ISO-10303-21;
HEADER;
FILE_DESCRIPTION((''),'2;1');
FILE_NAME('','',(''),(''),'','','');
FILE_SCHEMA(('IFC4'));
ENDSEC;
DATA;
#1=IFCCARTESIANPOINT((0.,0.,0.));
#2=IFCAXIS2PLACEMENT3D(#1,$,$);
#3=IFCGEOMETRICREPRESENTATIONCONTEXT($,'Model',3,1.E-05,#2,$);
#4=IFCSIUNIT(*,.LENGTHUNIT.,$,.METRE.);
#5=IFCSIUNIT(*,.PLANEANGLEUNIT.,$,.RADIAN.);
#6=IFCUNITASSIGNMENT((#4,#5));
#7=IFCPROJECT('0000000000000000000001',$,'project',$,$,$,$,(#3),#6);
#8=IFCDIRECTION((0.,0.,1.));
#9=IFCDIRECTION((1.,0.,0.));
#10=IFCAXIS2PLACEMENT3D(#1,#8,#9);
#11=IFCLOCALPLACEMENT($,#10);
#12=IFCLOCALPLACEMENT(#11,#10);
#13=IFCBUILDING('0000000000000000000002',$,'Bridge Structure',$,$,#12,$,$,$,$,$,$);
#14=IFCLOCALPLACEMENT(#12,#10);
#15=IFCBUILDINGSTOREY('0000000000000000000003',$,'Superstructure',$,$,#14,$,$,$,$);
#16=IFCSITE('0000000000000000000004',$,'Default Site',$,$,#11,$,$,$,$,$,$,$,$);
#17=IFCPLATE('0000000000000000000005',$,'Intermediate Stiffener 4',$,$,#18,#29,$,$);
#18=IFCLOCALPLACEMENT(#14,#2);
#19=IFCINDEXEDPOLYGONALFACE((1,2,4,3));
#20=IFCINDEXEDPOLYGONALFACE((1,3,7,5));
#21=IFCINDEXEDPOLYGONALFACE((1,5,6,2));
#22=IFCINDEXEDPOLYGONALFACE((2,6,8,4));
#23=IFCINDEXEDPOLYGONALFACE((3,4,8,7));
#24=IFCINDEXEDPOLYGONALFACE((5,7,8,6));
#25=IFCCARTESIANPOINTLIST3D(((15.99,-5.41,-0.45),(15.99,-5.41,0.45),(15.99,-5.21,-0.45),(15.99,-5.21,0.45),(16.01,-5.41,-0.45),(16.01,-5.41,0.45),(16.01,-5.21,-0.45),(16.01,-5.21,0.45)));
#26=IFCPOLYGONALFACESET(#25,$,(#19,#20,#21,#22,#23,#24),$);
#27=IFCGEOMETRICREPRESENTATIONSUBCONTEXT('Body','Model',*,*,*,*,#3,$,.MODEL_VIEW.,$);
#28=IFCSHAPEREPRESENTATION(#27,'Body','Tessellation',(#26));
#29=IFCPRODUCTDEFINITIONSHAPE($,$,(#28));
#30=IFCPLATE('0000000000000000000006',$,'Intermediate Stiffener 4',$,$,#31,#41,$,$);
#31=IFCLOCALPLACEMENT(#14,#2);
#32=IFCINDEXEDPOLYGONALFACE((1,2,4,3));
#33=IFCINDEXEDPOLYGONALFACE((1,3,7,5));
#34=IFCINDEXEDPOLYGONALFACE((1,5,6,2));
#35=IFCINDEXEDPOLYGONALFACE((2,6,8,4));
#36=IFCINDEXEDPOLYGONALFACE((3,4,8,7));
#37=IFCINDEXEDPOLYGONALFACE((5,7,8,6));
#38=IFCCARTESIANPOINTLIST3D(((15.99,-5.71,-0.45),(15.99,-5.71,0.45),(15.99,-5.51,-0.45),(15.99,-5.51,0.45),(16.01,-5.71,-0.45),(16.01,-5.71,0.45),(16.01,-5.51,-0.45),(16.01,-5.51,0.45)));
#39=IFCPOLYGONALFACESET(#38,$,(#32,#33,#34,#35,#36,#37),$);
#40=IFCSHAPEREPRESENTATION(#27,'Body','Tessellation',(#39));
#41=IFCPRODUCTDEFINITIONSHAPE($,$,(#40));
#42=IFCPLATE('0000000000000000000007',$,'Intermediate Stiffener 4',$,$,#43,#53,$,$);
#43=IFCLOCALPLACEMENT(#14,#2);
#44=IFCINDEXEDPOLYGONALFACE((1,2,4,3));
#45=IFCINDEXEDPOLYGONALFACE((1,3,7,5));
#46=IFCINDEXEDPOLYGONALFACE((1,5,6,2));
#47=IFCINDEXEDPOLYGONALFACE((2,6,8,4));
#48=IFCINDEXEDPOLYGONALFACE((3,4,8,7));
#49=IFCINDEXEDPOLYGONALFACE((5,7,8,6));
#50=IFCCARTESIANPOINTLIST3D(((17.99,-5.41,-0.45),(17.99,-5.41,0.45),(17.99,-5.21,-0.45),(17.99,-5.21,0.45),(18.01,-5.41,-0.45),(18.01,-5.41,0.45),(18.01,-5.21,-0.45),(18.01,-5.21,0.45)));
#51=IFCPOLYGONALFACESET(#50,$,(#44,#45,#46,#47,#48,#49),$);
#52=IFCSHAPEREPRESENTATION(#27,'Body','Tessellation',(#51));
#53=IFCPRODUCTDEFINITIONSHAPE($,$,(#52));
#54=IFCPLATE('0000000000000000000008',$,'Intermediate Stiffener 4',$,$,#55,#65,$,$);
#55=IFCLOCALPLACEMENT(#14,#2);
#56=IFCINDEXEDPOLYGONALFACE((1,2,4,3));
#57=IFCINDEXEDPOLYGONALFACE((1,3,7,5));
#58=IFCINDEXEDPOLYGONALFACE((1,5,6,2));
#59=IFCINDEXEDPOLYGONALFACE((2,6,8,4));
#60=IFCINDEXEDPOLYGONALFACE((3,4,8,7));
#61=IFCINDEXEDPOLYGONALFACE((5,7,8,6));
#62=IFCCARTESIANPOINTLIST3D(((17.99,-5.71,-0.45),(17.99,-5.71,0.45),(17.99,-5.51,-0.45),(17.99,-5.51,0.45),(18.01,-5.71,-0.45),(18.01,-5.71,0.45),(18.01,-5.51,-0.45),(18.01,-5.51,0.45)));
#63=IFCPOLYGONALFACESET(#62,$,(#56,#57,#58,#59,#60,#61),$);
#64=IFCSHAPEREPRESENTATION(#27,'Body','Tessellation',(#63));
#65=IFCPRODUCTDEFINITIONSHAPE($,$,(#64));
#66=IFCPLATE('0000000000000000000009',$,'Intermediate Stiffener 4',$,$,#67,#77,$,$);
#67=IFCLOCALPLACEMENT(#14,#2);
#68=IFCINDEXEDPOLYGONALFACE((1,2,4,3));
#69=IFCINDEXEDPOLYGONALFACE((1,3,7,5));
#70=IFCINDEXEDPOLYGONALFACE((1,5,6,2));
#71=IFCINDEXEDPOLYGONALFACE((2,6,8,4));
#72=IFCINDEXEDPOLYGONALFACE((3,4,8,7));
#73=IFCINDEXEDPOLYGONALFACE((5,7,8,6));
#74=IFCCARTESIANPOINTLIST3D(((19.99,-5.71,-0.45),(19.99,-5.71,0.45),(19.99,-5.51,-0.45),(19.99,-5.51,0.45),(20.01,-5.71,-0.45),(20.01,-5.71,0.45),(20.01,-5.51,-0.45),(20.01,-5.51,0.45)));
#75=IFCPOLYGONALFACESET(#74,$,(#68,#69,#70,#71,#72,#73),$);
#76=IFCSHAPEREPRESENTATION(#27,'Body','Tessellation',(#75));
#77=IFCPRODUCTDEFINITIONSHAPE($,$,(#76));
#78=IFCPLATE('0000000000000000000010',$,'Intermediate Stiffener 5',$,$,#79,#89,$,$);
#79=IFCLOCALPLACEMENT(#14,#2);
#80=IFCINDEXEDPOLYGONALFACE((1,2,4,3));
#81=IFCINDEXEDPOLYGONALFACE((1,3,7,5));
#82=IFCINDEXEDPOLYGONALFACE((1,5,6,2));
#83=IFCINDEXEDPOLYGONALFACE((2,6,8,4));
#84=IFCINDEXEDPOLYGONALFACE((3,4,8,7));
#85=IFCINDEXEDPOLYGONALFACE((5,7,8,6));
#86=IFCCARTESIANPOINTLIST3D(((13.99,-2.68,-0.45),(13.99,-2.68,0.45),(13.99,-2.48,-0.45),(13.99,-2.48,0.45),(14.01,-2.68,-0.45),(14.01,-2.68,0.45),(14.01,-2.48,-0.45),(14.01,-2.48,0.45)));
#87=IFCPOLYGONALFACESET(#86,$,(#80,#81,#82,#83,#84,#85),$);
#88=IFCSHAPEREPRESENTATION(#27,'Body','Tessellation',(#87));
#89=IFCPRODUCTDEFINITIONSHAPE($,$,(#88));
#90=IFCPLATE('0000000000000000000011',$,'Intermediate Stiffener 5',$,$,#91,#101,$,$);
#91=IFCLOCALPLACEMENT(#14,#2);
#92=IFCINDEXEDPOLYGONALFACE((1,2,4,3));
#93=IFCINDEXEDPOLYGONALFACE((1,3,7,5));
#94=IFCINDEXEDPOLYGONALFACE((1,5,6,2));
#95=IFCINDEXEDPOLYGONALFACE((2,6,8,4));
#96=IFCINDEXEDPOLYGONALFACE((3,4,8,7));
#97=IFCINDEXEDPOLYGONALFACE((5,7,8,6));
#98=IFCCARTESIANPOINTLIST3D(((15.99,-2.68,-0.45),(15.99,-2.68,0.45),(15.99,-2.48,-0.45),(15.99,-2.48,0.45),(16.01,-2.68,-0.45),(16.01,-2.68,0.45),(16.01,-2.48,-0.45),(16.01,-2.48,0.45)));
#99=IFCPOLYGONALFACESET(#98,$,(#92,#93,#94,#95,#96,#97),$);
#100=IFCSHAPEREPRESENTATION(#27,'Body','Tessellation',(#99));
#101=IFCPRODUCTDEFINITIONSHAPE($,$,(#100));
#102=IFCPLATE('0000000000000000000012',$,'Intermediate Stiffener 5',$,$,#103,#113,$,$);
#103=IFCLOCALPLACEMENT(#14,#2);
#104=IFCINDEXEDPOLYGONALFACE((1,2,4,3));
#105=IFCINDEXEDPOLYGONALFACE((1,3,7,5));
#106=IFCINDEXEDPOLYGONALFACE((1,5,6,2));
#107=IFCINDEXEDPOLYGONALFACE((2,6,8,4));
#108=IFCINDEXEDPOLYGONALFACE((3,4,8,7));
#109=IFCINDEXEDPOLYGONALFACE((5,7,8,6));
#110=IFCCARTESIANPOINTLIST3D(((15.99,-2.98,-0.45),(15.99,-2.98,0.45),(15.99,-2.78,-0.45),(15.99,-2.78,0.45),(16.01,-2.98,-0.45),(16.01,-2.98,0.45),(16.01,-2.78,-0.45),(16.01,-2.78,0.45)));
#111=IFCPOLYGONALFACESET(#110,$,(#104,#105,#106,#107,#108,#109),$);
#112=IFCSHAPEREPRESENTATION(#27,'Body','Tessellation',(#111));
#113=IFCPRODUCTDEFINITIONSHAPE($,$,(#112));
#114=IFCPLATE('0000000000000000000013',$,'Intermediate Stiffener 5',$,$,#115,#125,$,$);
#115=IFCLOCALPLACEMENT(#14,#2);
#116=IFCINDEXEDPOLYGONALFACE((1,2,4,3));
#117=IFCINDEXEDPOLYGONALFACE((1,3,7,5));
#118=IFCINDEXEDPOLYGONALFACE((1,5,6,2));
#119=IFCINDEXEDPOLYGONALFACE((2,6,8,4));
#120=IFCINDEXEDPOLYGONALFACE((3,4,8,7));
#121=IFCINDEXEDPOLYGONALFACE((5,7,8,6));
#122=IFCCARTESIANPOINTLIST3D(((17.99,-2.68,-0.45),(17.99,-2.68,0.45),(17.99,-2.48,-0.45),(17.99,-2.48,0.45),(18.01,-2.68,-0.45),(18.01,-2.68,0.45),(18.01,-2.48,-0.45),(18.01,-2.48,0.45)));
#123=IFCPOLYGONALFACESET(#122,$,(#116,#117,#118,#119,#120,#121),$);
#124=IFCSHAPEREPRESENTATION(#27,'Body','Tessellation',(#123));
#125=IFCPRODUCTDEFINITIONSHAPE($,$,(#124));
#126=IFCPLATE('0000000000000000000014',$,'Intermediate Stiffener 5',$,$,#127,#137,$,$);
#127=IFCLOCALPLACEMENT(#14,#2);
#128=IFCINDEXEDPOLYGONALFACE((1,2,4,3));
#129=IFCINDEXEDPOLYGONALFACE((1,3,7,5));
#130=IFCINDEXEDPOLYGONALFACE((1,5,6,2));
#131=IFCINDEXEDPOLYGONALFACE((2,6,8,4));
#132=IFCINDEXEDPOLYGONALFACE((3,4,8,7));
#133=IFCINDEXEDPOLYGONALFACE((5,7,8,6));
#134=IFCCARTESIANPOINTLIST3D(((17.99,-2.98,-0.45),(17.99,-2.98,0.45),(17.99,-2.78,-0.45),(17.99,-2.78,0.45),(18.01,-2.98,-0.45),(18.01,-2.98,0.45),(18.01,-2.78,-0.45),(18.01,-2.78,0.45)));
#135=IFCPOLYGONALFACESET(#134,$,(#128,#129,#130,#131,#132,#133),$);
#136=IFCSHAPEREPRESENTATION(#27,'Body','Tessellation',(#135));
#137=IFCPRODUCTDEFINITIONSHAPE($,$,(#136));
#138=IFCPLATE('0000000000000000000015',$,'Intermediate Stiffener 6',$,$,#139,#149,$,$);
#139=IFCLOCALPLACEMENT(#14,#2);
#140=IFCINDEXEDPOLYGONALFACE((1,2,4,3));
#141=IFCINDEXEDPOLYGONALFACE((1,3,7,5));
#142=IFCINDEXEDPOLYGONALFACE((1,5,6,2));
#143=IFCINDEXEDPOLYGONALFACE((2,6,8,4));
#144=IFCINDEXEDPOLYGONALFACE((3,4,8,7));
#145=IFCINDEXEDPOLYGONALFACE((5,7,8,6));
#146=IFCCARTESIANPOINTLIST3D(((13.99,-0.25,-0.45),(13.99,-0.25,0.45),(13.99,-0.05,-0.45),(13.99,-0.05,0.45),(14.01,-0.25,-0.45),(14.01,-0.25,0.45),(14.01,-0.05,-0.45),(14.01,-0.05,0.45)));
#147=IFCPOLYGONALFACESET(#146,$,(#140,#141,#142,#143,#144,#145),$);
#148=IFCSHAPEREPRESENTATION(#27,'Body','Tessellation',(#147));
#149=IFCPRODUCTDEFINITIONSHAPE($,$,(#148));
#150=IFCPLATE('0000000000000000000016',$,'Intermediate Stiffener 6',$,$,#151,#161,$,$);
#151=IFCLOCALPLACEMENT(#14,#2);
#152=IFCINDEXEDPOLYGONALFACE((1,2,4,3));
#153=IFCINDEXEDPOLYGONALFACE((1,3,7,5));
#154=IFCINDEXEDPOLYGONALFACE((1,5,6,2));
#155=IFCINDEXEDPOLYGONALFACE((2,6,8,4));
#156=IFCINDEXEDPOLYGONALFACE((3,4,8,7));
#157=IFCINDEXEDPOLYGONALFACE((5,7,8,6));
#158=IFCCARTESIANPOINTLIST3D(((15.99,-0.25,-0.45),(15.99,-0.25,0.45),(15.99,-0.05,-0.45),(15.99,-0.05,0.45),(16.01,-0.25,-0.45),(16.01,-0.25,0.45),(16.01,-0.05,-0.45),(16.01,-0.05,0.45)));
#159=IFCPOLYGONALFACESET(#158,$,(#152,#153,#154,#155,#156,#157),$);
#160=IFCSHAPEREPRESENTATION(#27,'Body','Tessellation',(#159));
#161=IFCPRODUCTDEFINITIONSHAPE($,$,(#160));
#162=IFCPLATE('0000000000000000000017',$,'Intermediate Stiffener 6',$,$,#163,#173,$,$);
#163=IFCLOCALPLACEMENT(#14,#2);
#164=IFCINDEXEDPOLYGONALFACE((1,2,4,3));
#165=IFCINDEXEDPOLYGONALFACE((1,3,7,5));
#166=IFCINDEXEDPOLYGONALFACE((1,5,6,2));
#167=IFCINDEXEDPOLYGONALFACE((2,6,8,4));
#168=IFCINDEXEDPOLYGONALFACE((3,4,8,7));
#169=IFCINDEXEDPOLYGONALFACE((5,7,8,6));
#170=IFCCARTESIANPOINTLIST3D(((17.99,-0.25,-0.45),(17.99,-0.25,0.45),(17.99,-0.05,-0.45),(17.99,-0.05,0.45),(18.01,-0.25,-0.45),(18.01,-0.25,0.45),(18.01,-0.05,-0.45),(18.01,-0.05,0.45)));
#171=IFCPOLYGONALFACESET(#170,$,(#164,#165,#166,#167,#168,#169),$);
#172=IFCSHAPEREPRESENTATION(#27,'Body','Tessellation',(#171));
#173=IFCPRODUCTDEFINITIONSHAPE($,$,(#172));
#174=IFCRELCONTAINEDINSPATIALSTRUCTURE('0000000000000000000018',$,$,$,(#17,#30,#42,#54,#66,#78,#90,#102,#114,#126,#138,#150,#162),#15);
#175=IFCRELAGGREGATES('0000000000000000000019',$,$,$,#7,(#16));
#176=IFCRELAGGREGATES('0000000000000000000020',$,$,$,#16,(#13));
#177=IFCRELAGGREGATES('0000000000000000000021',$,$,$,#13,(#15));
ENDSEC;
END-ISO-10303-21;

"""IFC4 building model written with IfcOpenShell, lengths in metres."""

from ifc_helpers import new_model, si_unit, frame, origin, origin_with_axes, origin_2d_with_axis, place, context, subcontext, project, spatial, rectangle, extrude, element, save


model = new_model("IFC4")

# Units and contexts
model_context = context("Model", 3, precision=1e-05, world=origin())
body_context = subcontext(model_context, "Body", "Model", "MODEL_VIEW")
ifc_project = project(units=[si_unit("LENGTHUNIT", "METRE"), si_unit("PLANEANGLEUNIT", "RADIAN")], contexts=[model_context])

# Site, building, storey
site_placement = place(None, origin_with_axes())
site = spatial("IfcSite", under=ifc_project, at=site_placement, Name="Default Site")
building_placement = place(site_placement, origin_with_axes())
building = spatial("IfcBuilding", under=site, at=building_placement, Name="Bridge Structure")
storey_placement = place(building_placement, origin_with_axes())
storey = spatial("IfcBuildingStorey", under=building, at=storey_placement, Name="Superstructure")

# Plates
for number, where, z_axis, x_axis, name in (
    (1, (16.0, -5.31, -0.45), (0.0, 0.0, 1.0), (1.0, 0.0, 0.0), "Intermediate Stiffener 4"),
    (2, (16.0, -5.61, -0.45), (0.0, 0.0, 1.0), (1.0, 0.0, 0.0), "Intermediate Stiffener 4"),
    (3, (18.0, -5.31, -0.45), (0.0, 0.0, 1.0), (1.0, 0.0, 0.0), "Intermediate Stiffener 4"),
    (4, (18.0, -5.61, -0.45), (0.0, 0.0, 1.0), (1.0, 0.0, 0.0), "Intermediate Stiffener 4"),
    (5, (20.0, -5.61, -0.45), (0.0, 0.0, 1.0), (1.0, 0.0, 0.0), "Intermediate Stiffener 4"),
    (6, (14.0, -2.58, -0.45), (0.0, 0.0, 1.0), (1.0, 0.0, 0.0), "Intermediate Stiffener 5"),
    (7, (16.0, -2.58, -0.45), (0.0, 0.0, 1.0), (1.0, 0.0, 0.0), "Intermediate Stiffener 5"),
    (8, (16.0, -2.88, -0.45), (0.0, 0.0, 1.0), (1.0, 0.0, 0.0), "Intermediate Stiffener 5"),
    (9, (18.0, -2.58, -0.45), (0.0, 0.0, 1.0), (1.0, 0.0, 0.0), "Intermediate Stiffener 5"),
    (10, (18.0, -2.88, -0.45), (0.0, 0.0, 1.0), (1.0, 0.0, 0.0), "Intermediate Stiffener 5"),
    (11, (14.0, -0.15, -0.45), (0.0, 0.0, 1.0), (1.0, 0.0, 0.0), "Intermediate Stiffener 6"),
    (12, (16.0, -0.15, -0.45), (0.0, 0.0, 1.0), (1.0, 0.0, 0.0), "Intermediate Stiffener 6"),
    (13, (18.0, -0.15, -0.45), (0.0, 0.0, 1.0), (1.0, 0.0, 0.0), "Intermediate Stiffener 6"),
):
    element("IfcPlate", number, at=place(storey_placement, frame(where, z_axis=z_axis, x_axis=x_axis)), inside=storey, Name=name, context=body_context, shape_type="SweptSolid", body=[
        extrude(rectangle(XDim=0.02, YDim=0.2, at=origin_2d_with_axis()), origin_with_axes(), (0.0, 0.0, 1.0), 0.9),
    ])

save(model, "model.ifc")
